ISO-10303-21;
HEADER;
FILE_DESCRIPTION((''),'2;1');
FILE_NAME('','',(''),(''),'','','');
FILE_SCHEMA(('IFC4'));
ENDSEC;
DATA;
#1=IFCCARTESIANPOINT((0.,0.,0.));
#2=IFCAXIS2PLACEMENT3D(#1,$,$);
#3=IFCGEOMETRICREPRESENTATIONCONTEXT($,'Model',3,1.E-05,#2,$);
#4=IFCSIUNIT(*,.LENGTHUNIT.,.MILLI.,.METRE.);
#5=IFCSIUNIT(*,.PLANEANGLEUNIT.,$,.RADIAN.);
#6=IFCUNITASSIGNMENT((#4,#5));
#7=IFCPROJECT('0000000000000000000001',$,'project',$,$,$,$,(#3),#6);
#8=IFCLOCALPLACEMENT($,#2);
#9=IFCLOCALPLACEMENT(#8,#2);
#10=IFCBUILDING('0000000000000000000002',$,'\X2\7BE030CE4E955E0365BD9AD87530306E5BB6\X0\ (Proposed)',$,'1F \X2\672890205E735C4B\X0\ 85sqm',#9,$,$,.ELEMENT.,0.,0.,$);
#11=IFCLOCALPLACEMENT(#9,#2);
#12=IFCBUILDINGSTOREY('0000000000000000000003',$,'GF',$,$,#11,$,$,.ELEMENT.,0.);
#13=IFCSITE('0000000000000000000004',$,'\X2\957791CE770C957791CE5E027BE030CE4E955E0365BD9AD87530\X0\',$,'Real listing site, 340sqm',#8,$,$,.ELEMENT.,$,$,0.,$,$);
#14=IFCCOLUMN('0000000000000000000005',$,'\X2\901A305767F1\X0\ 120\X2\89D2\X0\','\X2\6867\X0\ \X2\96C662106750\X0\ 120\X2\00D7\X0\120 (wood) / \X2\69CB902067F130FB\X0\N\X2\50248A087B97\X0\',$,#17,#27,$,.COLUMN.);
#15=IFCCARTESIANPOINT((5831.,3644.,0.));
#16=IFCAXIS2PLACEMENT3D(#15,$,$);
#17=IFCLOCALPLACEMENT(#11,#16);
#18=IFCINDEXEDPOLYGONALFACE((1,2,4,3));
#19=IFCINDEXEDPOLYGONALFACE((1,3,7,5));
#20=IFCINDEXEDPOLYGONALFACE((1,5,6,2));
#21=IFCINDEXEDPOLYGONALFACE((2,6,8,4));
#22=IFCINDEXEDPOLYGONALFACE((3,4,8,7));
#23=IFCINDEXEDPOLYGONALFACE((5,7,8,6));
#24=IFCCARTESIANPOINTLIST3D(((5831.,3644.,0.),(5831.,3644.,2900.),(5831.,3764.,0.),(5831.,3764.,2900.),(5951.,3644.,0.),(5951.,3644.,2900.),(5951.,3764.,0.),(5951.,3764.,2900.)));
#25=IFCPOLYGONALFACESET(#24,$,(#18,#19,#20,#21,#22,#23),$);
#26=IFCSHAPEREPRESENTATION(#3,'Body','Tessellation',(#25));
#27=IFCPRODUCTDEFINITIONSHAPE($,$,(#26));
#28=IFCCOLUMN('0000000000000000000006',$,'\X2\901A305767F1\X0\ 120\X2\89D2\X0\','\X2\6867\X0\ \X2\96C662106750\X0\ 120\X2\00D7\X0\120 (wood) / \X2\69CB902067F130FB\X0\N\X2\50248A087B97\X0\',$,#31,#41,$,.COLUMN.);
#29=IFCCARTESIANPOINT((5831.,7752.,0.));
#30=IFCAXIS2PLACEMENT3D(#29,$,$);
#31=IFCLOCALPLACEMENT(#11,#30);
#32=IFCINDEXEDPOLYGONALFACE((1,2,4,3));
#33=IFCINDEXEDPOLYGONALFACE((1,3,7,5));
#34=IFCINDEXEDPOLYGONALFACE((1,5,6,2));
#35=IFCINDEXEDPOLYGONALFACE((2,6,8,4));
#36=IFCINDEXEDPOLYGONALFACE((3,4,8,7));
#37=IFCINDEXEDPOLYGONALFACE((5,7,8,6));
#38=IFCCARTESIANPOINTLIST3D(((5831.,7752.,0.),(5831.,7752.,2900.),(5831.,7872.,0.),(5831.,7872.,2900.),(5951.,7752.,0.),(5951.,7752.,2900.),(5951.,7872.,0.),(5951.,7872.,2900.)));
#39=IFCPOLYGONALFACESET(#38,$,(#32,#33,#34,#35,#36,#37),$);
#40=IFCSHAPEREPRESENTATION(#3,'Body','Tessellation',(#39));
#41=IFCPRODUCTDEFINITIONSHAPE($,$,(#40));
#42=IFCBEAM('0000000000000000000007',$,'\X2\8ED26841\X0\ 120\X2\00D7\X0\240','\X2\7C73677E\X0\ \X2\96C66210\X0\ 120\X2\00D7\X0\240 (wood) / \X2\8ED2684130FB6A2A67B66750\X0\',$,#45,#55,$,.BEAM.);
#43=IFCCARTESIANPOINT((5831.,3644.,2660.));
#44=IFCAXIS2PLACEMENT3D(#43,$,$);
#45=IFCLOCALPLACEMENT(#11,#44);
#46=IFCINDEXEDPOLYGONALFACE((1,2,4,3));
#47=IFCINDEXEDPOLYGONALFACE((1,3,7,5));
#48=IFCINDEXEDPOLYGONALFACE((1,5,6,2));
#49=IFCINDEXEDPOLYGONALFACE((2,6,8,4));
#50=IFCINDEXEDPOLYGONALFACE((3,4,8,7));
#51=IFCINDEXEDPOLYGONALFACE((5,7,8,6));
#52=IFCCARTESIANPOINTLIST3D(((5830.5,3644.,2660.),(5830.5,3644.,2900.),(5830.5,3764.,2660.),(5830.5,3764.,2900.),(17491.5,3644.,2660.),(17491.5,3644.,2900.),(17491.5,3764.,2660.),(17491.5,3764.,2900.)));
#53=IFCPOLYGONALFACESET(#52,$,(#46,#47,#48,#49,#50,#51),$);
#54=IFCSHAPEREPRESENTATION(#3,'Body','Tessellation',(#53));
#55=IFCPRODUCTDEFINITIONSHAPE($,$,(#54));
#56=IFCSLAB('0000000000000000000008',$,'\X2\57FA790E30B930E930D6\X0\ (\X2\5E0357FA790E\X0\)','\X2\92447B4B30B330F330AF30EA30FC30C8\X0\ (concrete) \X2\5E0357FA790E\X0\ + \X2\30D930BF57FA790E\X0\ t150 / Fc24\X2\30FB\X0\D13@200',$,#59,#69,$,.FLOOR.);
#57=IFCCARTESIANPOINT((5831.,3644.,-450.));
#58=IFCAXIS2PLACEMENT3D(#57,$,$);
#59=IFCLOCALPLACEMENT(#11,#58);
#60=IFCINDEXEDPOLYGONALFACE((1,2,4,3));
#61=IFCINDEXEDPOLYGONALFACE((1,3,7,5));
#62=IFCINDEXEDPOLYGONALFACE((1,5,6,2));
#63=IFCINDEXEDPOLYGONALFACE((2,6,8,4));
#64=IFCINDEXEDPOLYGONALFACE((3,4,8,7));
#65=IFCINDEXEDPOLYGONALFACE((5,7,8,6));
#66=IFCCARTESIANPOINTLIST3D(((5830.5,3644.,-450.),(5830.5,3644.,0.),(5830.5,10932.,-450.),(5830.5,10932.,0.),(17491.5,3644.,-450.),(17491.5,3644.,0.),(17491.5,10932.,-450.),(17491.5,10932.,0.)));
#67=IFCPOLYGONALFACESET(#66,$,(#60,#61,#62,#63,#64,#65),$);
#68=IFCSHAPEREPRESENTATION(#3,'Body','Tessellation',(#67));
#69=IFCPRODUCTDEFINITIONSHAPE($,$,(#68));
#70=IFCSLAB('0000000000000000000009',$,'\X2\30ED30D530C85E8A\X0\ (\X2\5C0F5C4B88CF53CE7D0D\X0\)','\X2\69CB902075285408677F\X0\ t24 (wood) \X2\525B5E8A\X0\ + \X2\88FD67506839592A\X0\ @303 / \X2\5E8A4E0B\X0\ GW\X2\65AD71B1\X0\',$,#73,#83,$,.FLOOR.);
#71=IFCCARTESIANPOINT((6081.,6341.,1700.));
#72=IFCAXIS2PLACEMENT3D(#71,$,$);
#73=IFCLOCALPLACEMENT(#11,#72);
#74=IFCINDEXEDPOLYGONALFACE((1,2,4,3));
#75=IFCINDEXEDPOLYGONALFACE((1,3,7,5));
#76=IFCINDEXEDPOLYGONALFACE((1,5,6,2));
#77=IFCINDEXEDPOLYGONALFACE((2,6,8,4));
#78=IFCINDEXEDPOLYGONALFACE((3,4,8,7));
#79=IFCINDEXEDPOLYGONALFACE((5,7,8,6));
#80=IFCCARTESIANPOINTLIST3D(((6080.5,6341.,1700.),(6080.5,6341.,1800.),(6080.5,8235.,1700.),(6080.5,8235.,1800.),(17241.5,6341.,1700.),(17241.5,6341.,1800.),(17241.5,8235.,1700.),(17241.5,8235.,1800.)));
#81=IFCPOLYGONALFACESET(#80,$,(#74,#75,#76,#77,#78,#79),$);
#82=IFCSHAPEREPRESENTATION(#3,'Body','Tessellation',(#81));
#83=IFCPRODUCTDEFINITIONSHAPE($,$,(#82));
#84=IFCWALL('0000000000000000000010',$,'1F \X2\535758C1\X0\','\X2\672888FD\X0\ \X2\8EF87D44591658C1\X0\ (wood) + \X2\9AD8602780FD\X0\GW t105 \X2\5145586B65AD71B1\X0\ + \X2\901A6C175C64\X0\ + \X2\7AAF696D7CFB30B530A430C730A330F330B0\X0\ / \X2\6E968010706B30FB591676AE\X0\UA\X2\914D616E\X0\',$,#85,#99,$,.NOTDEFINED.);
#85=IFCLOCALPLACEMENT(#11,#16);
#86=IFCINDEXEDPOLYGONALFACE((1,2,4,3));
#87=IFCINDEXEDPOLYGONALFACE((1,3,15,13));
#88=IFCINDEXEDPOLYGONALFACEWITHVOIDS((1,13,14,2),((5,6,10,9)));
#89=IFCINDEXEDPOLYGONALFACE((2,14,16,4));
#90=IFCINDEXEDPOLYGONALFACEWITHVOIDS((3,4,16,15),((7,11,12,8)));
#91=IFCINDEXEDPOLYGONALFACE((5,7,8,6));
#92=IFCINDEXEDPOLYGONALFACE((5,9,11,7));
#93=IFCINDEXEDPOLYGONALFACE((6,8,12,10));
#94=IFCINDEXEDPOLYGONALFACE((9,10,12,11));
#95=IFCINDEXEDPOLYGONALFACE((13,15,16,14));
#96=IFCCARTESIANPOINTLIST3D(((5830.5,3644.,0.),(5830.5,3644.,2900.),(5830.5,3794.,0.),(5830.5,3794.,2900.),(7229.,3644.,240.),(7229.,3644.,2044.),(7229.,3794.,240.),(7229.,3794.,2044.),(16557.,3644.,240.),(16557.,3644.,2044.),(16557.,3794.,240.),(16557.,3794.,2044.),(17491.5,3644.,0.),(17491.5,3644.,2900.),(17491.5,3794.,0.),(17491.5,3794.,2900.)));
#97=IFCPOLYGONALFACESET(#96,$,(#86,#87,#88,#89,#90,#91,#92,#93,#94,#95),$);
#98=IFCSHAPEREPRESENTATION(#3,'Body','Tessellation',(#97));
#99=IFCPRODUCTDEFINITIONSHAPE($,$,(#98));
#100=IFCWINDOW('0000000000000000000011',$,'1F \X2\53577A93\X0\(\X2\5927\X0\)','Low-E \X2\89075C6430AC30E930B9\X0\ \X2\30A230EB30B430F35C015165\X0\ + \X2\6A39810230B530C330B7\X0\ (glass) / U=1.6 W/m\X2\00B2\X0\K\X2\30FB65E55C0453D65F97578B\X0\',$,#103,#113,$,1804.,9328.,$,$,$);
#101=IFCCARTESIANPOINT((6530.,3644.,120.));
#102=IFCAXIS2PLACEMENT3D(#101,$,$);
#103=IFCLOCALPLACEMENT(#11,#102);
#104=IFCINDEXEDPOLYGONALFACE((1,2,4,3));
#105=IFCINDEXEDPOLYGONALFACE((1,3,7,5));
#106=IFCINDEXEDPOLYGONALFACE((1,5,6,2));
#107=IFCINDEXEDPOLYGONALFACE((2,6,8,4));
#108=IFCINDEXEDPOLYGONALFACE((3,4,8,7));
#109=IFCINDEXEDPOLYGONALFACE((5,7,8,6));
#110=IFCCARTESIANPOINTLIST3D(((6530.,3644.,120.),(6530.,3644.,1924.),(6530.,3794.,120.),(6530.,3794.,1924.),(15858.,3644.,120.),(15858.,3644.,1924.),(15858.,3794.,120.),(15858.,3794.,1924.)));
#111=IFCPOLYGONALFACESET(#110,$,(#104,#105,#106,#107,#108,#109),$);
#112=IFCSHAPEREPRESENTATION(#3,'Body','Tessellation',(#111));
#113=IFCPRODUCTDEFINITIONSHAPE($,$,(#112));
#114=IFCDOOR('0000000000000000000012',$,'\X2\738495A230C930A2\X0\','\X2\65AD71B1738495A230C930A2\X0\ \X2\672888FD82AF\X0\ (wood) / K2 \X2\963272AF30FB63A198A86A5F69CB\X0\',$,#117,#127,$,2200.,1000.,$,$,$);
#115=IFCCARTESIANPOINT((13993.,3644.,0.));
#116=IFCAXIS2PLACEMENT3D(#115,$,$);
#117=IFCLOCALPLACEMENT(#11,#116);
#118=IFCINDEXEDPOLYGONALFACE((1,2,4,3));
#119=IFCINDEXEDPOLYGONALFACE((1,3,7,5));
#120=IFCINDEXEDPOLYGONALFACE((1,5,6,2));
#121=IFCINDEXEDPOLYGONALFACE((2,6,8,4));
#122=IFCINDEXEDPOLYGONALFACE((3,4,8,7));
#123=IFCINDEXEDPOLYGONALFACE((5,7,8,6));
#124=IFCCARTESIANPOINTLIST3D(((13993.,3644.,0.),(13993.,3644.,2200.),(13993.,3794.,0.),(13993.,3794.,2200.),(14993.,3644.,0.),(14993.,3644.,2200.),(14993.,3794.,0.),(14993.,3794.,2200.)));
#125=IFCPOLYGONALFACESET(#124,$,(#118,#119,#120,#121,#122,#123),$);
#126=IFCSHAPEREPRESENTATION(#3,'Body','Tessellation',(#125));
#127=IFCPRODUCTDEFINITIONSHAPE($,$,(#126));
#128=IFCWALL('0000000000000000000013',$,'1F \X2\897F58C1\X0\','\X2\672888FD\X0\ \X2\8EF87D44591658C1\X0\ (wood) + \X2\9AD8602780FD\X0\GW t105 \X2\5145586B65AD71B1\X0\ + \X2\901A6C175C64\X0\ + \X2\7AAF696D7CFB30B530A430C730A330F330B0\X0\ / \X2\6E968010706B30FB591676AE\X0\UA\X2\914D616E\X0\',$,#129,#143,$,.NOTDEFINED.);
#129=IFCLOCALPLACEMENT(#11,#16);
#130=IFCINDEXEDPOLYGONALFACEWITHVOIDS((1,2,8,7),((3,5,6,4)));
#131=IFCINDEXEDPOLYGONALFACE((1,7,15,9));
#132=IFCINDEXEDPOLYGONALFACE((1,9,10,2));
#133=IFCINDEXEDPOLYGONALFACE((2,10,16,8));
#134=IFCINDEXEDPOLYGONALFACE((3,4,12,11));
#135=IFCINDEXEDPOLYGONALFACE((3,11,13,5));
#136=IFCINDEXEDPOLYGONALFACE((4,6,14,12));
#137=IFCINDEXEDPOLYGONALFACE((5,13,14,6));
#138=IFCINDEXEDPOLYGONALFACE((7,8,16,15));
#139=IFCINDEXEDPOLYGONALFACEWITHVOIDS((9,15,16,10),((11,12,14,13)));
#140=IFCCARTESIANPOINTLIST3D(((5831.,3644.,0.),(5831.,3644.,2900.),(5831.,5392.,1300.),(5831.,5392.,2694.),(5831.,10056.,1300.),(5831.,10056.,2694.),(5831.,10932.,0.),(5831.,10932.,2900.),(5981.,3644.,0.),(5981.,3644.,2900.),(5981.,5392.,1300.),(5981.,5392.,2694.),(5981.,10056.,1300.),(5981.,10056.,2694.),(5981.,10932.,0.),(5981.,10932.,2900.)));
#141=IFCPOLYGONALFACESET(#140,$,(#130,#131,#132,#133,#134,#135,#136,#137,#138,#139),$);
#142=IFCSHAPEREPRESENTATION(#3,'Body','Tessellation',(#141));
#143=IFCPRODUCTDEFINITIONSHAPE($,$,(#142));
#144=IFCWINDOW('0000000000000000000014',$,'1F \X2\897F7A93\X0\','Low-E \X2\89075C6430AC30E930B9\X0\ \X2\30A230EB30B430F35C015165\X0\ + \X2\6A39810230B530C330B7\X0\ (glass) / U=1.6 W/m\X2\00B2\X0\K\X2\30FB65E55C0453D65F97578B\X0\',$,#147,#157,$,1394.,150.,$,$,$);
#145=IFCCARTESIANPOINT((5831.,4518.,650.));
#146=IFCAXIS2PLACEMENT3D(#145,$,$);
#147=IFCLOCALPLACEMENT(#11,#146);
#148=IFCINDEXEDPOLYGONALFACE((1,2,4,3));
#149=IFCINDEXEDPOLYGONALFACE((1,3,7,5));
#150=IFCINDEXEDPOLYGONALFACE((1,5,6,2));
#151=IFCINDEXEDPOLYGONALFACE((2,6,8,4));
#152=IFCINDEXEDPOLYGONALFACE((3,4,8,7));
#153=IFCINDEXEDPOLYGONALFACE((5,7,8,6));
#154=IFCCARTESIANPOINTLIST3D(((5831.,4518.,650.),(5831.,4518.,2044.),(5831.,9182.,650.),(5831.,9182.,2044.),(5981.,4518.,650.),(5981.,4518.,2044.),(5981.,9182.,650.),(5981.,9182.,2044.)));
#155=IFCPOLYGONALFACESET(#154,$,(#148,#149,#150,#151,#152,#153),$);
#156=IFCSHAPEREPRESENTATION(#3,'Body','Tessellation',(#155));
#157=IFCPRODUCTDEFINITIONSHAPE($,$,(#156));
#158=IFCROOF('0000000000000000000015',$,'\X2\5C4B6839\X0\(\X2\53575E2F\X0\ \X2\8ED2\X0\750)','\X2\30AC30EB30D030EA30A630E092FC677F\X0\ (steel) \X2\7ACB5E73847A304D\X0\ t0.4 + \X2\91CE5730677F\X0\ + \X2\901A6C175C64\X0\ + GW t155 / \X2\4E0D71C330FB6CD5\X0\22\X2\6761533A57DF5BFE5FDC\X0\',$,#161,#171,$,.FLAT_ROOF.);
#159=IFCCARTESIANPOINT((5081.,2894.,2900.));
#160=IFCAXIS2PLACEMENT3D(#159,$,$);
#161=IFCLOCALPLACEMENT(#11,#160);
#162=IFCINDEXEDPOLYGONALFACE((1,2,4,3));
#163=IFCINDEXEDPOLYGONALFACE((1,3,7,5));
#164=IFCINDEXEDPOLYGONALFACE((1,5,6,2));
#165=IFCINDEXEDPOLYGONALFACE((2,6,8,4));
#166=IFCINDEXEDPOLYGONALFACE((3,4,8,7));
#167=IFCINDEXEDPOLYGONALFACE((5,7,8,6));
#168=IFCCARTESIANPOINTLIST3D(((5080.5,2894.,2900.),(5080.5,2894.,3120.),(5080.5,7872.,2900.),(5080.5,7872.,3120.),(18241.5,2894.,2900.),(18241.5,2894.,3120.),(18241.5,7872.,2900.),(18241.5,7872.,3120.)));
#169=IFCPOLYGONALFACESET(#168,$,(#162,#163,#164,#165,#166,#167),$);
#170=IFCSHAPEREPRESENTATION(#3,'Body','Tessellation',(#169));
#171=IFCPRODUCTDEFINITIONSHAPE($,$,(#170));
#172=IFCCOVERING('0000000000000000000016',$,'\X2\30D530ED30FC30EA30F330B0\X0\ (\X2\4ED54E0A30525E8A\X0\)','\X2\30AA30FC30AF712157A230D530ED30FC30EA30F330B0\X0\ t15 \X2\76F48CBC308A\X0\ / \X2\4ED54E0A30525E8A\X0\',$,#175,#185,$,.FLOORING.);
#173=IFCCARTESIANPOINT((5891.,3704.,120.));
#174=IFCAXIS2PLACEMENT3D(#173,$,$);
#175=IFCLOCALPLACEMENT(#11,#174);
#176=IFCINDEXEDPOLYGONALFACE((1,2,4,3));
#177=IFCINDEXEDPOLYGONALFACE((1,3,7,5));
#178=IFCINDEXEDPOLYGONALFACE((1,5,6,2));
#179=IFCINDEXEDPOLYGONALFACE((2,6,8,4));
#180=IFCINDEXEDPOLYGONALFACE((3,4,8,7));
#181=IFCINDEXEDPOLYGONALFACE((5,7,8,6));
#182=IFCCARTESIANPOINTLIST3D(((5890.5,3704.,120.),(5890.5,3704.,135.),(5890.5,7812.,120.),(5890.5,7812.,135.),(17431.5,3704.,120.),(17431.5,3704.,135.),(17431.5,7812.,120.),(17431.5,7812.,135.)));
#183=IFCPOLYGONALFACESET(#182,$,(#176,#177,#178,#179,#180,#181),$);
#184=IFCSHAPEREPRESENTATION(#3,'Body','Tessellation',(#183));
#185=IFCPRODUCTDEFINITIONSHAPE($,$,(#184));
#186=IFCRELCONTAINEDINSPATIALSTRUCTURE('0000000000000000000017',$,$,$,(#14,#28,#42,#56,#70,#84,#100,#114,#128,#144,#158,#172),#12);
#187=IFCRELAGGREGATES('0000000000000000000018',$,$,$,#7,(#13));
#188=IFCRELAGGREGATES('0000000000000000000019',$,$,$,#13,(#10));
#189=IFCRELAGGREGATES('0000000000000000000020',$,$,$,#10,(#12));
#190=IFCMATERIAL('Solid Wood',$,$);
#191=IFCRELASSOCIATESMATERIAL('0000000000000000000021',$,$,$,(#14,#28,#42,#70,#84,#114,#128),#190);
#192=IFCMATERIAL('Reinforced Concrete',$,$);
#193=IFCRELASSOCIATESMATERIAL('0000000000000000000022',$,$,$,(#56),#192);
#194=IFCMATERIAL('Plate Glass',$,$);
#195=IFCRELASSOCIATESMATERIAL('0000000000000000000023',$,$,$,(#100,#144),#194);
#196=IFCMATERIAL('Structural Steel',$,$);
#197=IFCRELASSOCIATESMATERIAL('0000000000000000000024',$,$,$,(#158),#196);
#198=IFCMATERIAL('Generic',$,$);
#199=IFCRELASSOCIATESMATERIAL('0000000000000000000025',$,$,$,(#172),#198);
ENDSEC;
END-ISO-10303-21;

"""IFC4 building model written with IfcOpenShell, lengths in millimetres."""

from ifc_helpers import new_model, si_unit, frame, frame_2d, origin, place, context, project, spatial, rectangle, extrude, material, element, fill, save


model = new_model("IFC4")

# Units and contexts
model_context = context("Model", 3, precision=1e-05, world=origin())
ifc_project = project(units=[si_unit("LENGTHUNIT", "METRE", prefix="MILLI"), si_unit("PLANEANGLEUNIT", "RADIAN")], contexts=[model_context])

# Site, building, storey
site_placement = place(None, origin())
site = spatial("IfcSite", under=ifc_project, at=site_placement, Name="長野県長野市篠ノ井布施高田", ObjectType="Real listing site, 340sqm", CompositionType="ELEMENT", RefElevation=0.0)
building_placement = place(site_placement, origin())
building = spatial("IfcBuilding", under=site, at=building_placement, Name="篠ノ井布施高田の家 (Proposed)", ObjectType="1F 木造平屋 85sqm", CompositionType="ELEMENT", ElevationOfRefHeight=0.0, ElevationOfTerrain=0.0)
storey_placement = place(building_placement, origin())
storey = spatial("IfcBuildingStorey", under=building, at=storey_placement, Name="GF", CompositionType="ELEMENT", Elevation=0.0)

# Columns
ifc_material_1 = material(Name="Solid Wood")
column_1_placement = place(storey_placement, frame((5831.0, 3644.0, 0.0)))
element("IfcColumn", 1, at=column_1_placement, inside=storey, material=ifc_material_1, Name="通し柱 120角", Description="桧 集成材 120×120 (wood) / 構造柱・N値計算", PredefinedType="COLUMN", context=model_context, shape_type="SweptSolid", body=[
    extrude(rectangle(XDim=120.0, YDim=120.0, at=frame_2d((60.0, 60.0))), frame((5831.0, 3644.0, 0.0)), (0.0, 0.0, 1.0), 2900.0),
])
column_2_placement = place(storey_placement, frame((5831.0, 7752.0, 0.0)))
element("IfcColumn", 2, at=column_2_placement, inside=storey, material=ifc_material_1, Name="通し柱 120角", Description="桧 集成材 120×120 (wood) / 構造柱・N値計算", PredefinedType="COLUMN", context=model_context, shape_type="SweptSolid", body=[
    extrude(rectangle(XDim=120.0, YDim=120.0, at=frame_2d((60.0, 60.0))), frame((5831.0, 7752.0, 0.0)), (0.0, 0.0, 1.0), 2900.0),
])

# Beam
beam_1_placement = place(storey_placement, frame((5831.0, 3644.0, 2660.0)))
element("IfcBeam", 3, at=beam_1_placement, inside=storey, material=ifc_material_1, Name="軒桁 120×240", Description="米松 集成 120×240 (wood) / 軒桁・横架材", PredefinedType="BEAM", context=model_context, shape_type="SweptSolid", body=[
    extrude(rectangle(XDim=11661.0, YDim=120.0, at=frame_2d((5830.0, 60.0))), frame((5831.0, 3644.0, 2660.0)), (0.0, 0.0, 1.0), 240.0),
])

# Slabs
ifc_material_2 = material(Name="Reinforced Concrete")
slab_1_placement = place(storey_placement, frame((5831.0, 3644.0, -450.0)))
element("IfcSlab", 4, at=slab_1_placement, inside=storey, material=ifc_material_2, Name="基礎スラブ (布基礎)", Description="鉄筋コンクリート (concrete) 布基礎 + ベタ基礎 t150 / Fc24・D13@200", PredefinedType="FLOOR", context=model_context, shape_type="SweptSolid", body=[
    extrude(rectangle(XDim=11661.0, YDim=7288.0, at=frame_2d((5830.0, 3644.0))), frame((5831.0, 3644.0, -450.0)), (0.0, 0.0, 1.0), 450.0),
])
slab_2_placement = place(storey_placement, frame((6081.0, 6341.0, 1700.0)))
element("IfcSlab", 5, at=slab_2_placement, inside=storey, material=ifc_material_1, Name="ロフト床 (小屋裏収納)", Description="構造用合板 t24 (wood) 剛床 + 製材根太 @303 / 床下 GW断熱", PredefinedType="FLOOR", context=model_context, shape_type="SweptSolid", body=[
    extrude(rectangle(XDim=11161.0, YDim=1894.0, at=frame_2d((5580.0, 947.0))), frame((6081.0, 6341.0, 1700.0)), (0.0, 0.0, 1.0), 100.0),
])

# Wall, openings, window, door
wall_1_placement = place(storey_placement, frame((5831.0, 3644.0, 0.0)))
wall_1 = element("IfcWall", 6, at=wall_1_placement, inside=storey, material=ifc_material_1, Name="1F 南壁", Description="木製 軸組外壁 (wood) + 高性能GW t105 充填断熱 + 通気層 + 窯業系サイディング / 準耐火・外皮UA配慮", PredefinedType="NOTDEFINED", context=model_context, shape_type="SweptSolid", body=[
    extrude(rectangle(XDim=11661.0, YDim=150.0, at=frame_2d((5830.0, 75.0))), frame((5831.0, 3644.0, 0.0)), (0.0, 0.0, 1.0), 2900.0),
])
opening_1_placement = place(storey_placement, frame((6530.0, 3644.0, 120.0)))
opening_1 = element("IfcOpeningElement", 7, at=opening_1_placement, cuts=wall_1, PredefinedType="NOTDEFINED", context=model_context, shape_type="SweptSolid", body=[
    extrude(rectangle(XDim=9328.0, YDim=150.0, at=frame_2d((4664.0, 75.0))), frame((6530.0, 3644.0, 120.0)), (0.0, 0.0, 1.0), 1804.0),
])
opening_2_placement = place(storey_placement, frame((13993.0, 3644.0, 0.0)))
opening_2 = element("IfcOpeningElement", 8, at=opening_2_placement, cuts=wall_1, PredefinedType="NOTDEFINED", context=model_context, shape_type="SweptSolid", body=[
    extrude(rectangle(XDim=1000.0, YDim=150.0, at=frame_2d((500.0, 75.0))), frame((13993.0, 3644.0, 0.0)), (0.0, 0.0, 1.0), 2200.0),
])
ifc_material_3 = material(Name="Plate Glass")
window_1_placement = place(storey_placement, frame((6530.0, 3644.0, 120.0)))
window_1 = element("IfcWindow", 9, at=window_1_placement, inside=storey, material=ifc_material_3, Name="1F 南窓(大)", Description="Low-E 複層ガラス アルゴン封入 + 樹脂サッシ (glass) / U=1.6 W/m²K・日射取得型", OverallHeight=1804.0, OverallWidth=9328.0, context=model_context, shape_type="SweptSolid", body=[
    extrude(rectangle(XDim=9328.0, YDim=150.0, at=frame_2d((4664.0, 75.0))), frame((6530.0, 3644.0, 120.0)), (0.0, 0.0, 1.0), 1804.0),
])
fill(opening_1, window_1)
door_placement = place(storey_placement, frame((13993.0, 3644.0, 0.0)))
door = element("IfcDoor", 10, at=door_placement, inside=storey, material=ifc_material_1, Name="玄関ドア", Description="断熱玄関ドア 木製芯 (wood) / K2 防犯・採風機構", OverallHeight=2200.0, OverallWidth=1000.0, context=model_context, shape_type="SweptSolid", body=[
    extrude(rectangle(XDim=1000.0, YDim=150.0, at=frame_2d((500.0, 75.0))), frame((13993.0, 3644.0, 0.0)), (0.0, 0.0, 1.0), 2200.0),
])
fill(opening_2, door)

# Wall, opening, window
wall_2_placement = place(storey_placement, frame((5831.0, 3644.0, 0.0)))
wall_2 = element("IfcWall", 11, at=wall_2_placement, inside=storey, material=ifc_material_1, Name="1F 西壁", Description="木製 軸組外壁 (wood) + 高性能GW t105 充填断熱 + 通気層 + 窯業系サイディング / 準耐火・外皮UA配慮", PredefinedType="NOTDEFINED", context=model_context, shape_type="SweptSolid", body=[
    extrude(rectangle(XDim=150.0, YDim=7288.0, at=frame_2d((75.0, 3644.0))), frame((5831.0, 3644.0, 0.0)), (0.0, 0.0, 1.0), 2900.0),
])
opening_3_placement = place(storey_placement, frame((5831.0, 4518.0, 650.0)))
opening_3 = element("IfcOpeningElement", 12, at=opening_3_placement, cuts=wall_2, PredefinedType="NOTDEFINED", context=model_context, shape_type="SweptSolid", body=[
    extrude(rectangle(XDim=150.0, YDim=4664.0, at=frame_2d((75.0, 2332.0))), frame((5831.0, 4518.0, 650.0)), (0.0, 0.0, 1.0), 1394.0),
])
window_2_placement = place(storey_placement, frame((5831.0, 4518.0, 650.0)))
window_2 = element("IfcWindow", 13, at=window_2_placement, inside=storey, material=ifc_material_3, Name="1F 西窓", Description="Low-E 複層ガラス アルゴン封入 + 樹脂サッシ (glass) / U=1.6 W/m²K・日射取得型", OverallHeight=1394.0, OverallWidth=150.0, context=model_context, shape_type="SweptSolid", body=[
    extrude(rectangle(XDim=150.0, YDim=4664.0, at=frame_2d((75.0, 2332.0))), frame((5831.0, 4518.0, 650.0)), (0.0, 0.0, 1.0), 1394.0),
])
fill(opening_3, window_2)

# Roof
ifc_material_4 = material(Name="Structural Steel")
roof_placement = place(storey_placement, frame((5081.0, 2894.0, 2900.0)))
element("IfcRoof", 14, at=roof_placement, inside=storey, material=ifc_material_4, Name="屋根(南帯 軒750)", Description="ガルバリウム鋼板 (steel) 立平葺き t0.4 + 野地板 + 通気層 + GW t155 / 不燃・法22条区域対応", PredefinedType="FLAT_ROOF", context=model_context, shape_type="SweptSolid", body=[
    extrude(rectangle(XDim=13161.0, YDim=4978.0, at=frame_2d((6580.0, 2489.0))), frame((5081.0, 2894.0, 2900.0)), (0.0, 0.0, 1.0), 220.0),
])

# Covering
ifc_material_5 = material(Name="Generic")
covering_1_placement = place(storey_placement, frame((5891.0, 3704.0, 120.0)))
element("IfcCovering", 15, at=covering_1_placement, inside=storey, material=ifc_material_5, Name="フローリング (仕上げ床)", Description="オーク無垢フローリング t15 直貼り / 仕上げ床", PredefinedType="FLOORING", context=model_context, shape_type="SweptSolid", body=[
    extrude(rectangle(XDim=11541.0, YDim=4108.0, at=frame_2d((5770.0, 2054.0))), frame((5891.0, 3704.0, 120.0)), (0.0, 0.0, 1.0), 15.0),
])

save(model, "model.ifc")
